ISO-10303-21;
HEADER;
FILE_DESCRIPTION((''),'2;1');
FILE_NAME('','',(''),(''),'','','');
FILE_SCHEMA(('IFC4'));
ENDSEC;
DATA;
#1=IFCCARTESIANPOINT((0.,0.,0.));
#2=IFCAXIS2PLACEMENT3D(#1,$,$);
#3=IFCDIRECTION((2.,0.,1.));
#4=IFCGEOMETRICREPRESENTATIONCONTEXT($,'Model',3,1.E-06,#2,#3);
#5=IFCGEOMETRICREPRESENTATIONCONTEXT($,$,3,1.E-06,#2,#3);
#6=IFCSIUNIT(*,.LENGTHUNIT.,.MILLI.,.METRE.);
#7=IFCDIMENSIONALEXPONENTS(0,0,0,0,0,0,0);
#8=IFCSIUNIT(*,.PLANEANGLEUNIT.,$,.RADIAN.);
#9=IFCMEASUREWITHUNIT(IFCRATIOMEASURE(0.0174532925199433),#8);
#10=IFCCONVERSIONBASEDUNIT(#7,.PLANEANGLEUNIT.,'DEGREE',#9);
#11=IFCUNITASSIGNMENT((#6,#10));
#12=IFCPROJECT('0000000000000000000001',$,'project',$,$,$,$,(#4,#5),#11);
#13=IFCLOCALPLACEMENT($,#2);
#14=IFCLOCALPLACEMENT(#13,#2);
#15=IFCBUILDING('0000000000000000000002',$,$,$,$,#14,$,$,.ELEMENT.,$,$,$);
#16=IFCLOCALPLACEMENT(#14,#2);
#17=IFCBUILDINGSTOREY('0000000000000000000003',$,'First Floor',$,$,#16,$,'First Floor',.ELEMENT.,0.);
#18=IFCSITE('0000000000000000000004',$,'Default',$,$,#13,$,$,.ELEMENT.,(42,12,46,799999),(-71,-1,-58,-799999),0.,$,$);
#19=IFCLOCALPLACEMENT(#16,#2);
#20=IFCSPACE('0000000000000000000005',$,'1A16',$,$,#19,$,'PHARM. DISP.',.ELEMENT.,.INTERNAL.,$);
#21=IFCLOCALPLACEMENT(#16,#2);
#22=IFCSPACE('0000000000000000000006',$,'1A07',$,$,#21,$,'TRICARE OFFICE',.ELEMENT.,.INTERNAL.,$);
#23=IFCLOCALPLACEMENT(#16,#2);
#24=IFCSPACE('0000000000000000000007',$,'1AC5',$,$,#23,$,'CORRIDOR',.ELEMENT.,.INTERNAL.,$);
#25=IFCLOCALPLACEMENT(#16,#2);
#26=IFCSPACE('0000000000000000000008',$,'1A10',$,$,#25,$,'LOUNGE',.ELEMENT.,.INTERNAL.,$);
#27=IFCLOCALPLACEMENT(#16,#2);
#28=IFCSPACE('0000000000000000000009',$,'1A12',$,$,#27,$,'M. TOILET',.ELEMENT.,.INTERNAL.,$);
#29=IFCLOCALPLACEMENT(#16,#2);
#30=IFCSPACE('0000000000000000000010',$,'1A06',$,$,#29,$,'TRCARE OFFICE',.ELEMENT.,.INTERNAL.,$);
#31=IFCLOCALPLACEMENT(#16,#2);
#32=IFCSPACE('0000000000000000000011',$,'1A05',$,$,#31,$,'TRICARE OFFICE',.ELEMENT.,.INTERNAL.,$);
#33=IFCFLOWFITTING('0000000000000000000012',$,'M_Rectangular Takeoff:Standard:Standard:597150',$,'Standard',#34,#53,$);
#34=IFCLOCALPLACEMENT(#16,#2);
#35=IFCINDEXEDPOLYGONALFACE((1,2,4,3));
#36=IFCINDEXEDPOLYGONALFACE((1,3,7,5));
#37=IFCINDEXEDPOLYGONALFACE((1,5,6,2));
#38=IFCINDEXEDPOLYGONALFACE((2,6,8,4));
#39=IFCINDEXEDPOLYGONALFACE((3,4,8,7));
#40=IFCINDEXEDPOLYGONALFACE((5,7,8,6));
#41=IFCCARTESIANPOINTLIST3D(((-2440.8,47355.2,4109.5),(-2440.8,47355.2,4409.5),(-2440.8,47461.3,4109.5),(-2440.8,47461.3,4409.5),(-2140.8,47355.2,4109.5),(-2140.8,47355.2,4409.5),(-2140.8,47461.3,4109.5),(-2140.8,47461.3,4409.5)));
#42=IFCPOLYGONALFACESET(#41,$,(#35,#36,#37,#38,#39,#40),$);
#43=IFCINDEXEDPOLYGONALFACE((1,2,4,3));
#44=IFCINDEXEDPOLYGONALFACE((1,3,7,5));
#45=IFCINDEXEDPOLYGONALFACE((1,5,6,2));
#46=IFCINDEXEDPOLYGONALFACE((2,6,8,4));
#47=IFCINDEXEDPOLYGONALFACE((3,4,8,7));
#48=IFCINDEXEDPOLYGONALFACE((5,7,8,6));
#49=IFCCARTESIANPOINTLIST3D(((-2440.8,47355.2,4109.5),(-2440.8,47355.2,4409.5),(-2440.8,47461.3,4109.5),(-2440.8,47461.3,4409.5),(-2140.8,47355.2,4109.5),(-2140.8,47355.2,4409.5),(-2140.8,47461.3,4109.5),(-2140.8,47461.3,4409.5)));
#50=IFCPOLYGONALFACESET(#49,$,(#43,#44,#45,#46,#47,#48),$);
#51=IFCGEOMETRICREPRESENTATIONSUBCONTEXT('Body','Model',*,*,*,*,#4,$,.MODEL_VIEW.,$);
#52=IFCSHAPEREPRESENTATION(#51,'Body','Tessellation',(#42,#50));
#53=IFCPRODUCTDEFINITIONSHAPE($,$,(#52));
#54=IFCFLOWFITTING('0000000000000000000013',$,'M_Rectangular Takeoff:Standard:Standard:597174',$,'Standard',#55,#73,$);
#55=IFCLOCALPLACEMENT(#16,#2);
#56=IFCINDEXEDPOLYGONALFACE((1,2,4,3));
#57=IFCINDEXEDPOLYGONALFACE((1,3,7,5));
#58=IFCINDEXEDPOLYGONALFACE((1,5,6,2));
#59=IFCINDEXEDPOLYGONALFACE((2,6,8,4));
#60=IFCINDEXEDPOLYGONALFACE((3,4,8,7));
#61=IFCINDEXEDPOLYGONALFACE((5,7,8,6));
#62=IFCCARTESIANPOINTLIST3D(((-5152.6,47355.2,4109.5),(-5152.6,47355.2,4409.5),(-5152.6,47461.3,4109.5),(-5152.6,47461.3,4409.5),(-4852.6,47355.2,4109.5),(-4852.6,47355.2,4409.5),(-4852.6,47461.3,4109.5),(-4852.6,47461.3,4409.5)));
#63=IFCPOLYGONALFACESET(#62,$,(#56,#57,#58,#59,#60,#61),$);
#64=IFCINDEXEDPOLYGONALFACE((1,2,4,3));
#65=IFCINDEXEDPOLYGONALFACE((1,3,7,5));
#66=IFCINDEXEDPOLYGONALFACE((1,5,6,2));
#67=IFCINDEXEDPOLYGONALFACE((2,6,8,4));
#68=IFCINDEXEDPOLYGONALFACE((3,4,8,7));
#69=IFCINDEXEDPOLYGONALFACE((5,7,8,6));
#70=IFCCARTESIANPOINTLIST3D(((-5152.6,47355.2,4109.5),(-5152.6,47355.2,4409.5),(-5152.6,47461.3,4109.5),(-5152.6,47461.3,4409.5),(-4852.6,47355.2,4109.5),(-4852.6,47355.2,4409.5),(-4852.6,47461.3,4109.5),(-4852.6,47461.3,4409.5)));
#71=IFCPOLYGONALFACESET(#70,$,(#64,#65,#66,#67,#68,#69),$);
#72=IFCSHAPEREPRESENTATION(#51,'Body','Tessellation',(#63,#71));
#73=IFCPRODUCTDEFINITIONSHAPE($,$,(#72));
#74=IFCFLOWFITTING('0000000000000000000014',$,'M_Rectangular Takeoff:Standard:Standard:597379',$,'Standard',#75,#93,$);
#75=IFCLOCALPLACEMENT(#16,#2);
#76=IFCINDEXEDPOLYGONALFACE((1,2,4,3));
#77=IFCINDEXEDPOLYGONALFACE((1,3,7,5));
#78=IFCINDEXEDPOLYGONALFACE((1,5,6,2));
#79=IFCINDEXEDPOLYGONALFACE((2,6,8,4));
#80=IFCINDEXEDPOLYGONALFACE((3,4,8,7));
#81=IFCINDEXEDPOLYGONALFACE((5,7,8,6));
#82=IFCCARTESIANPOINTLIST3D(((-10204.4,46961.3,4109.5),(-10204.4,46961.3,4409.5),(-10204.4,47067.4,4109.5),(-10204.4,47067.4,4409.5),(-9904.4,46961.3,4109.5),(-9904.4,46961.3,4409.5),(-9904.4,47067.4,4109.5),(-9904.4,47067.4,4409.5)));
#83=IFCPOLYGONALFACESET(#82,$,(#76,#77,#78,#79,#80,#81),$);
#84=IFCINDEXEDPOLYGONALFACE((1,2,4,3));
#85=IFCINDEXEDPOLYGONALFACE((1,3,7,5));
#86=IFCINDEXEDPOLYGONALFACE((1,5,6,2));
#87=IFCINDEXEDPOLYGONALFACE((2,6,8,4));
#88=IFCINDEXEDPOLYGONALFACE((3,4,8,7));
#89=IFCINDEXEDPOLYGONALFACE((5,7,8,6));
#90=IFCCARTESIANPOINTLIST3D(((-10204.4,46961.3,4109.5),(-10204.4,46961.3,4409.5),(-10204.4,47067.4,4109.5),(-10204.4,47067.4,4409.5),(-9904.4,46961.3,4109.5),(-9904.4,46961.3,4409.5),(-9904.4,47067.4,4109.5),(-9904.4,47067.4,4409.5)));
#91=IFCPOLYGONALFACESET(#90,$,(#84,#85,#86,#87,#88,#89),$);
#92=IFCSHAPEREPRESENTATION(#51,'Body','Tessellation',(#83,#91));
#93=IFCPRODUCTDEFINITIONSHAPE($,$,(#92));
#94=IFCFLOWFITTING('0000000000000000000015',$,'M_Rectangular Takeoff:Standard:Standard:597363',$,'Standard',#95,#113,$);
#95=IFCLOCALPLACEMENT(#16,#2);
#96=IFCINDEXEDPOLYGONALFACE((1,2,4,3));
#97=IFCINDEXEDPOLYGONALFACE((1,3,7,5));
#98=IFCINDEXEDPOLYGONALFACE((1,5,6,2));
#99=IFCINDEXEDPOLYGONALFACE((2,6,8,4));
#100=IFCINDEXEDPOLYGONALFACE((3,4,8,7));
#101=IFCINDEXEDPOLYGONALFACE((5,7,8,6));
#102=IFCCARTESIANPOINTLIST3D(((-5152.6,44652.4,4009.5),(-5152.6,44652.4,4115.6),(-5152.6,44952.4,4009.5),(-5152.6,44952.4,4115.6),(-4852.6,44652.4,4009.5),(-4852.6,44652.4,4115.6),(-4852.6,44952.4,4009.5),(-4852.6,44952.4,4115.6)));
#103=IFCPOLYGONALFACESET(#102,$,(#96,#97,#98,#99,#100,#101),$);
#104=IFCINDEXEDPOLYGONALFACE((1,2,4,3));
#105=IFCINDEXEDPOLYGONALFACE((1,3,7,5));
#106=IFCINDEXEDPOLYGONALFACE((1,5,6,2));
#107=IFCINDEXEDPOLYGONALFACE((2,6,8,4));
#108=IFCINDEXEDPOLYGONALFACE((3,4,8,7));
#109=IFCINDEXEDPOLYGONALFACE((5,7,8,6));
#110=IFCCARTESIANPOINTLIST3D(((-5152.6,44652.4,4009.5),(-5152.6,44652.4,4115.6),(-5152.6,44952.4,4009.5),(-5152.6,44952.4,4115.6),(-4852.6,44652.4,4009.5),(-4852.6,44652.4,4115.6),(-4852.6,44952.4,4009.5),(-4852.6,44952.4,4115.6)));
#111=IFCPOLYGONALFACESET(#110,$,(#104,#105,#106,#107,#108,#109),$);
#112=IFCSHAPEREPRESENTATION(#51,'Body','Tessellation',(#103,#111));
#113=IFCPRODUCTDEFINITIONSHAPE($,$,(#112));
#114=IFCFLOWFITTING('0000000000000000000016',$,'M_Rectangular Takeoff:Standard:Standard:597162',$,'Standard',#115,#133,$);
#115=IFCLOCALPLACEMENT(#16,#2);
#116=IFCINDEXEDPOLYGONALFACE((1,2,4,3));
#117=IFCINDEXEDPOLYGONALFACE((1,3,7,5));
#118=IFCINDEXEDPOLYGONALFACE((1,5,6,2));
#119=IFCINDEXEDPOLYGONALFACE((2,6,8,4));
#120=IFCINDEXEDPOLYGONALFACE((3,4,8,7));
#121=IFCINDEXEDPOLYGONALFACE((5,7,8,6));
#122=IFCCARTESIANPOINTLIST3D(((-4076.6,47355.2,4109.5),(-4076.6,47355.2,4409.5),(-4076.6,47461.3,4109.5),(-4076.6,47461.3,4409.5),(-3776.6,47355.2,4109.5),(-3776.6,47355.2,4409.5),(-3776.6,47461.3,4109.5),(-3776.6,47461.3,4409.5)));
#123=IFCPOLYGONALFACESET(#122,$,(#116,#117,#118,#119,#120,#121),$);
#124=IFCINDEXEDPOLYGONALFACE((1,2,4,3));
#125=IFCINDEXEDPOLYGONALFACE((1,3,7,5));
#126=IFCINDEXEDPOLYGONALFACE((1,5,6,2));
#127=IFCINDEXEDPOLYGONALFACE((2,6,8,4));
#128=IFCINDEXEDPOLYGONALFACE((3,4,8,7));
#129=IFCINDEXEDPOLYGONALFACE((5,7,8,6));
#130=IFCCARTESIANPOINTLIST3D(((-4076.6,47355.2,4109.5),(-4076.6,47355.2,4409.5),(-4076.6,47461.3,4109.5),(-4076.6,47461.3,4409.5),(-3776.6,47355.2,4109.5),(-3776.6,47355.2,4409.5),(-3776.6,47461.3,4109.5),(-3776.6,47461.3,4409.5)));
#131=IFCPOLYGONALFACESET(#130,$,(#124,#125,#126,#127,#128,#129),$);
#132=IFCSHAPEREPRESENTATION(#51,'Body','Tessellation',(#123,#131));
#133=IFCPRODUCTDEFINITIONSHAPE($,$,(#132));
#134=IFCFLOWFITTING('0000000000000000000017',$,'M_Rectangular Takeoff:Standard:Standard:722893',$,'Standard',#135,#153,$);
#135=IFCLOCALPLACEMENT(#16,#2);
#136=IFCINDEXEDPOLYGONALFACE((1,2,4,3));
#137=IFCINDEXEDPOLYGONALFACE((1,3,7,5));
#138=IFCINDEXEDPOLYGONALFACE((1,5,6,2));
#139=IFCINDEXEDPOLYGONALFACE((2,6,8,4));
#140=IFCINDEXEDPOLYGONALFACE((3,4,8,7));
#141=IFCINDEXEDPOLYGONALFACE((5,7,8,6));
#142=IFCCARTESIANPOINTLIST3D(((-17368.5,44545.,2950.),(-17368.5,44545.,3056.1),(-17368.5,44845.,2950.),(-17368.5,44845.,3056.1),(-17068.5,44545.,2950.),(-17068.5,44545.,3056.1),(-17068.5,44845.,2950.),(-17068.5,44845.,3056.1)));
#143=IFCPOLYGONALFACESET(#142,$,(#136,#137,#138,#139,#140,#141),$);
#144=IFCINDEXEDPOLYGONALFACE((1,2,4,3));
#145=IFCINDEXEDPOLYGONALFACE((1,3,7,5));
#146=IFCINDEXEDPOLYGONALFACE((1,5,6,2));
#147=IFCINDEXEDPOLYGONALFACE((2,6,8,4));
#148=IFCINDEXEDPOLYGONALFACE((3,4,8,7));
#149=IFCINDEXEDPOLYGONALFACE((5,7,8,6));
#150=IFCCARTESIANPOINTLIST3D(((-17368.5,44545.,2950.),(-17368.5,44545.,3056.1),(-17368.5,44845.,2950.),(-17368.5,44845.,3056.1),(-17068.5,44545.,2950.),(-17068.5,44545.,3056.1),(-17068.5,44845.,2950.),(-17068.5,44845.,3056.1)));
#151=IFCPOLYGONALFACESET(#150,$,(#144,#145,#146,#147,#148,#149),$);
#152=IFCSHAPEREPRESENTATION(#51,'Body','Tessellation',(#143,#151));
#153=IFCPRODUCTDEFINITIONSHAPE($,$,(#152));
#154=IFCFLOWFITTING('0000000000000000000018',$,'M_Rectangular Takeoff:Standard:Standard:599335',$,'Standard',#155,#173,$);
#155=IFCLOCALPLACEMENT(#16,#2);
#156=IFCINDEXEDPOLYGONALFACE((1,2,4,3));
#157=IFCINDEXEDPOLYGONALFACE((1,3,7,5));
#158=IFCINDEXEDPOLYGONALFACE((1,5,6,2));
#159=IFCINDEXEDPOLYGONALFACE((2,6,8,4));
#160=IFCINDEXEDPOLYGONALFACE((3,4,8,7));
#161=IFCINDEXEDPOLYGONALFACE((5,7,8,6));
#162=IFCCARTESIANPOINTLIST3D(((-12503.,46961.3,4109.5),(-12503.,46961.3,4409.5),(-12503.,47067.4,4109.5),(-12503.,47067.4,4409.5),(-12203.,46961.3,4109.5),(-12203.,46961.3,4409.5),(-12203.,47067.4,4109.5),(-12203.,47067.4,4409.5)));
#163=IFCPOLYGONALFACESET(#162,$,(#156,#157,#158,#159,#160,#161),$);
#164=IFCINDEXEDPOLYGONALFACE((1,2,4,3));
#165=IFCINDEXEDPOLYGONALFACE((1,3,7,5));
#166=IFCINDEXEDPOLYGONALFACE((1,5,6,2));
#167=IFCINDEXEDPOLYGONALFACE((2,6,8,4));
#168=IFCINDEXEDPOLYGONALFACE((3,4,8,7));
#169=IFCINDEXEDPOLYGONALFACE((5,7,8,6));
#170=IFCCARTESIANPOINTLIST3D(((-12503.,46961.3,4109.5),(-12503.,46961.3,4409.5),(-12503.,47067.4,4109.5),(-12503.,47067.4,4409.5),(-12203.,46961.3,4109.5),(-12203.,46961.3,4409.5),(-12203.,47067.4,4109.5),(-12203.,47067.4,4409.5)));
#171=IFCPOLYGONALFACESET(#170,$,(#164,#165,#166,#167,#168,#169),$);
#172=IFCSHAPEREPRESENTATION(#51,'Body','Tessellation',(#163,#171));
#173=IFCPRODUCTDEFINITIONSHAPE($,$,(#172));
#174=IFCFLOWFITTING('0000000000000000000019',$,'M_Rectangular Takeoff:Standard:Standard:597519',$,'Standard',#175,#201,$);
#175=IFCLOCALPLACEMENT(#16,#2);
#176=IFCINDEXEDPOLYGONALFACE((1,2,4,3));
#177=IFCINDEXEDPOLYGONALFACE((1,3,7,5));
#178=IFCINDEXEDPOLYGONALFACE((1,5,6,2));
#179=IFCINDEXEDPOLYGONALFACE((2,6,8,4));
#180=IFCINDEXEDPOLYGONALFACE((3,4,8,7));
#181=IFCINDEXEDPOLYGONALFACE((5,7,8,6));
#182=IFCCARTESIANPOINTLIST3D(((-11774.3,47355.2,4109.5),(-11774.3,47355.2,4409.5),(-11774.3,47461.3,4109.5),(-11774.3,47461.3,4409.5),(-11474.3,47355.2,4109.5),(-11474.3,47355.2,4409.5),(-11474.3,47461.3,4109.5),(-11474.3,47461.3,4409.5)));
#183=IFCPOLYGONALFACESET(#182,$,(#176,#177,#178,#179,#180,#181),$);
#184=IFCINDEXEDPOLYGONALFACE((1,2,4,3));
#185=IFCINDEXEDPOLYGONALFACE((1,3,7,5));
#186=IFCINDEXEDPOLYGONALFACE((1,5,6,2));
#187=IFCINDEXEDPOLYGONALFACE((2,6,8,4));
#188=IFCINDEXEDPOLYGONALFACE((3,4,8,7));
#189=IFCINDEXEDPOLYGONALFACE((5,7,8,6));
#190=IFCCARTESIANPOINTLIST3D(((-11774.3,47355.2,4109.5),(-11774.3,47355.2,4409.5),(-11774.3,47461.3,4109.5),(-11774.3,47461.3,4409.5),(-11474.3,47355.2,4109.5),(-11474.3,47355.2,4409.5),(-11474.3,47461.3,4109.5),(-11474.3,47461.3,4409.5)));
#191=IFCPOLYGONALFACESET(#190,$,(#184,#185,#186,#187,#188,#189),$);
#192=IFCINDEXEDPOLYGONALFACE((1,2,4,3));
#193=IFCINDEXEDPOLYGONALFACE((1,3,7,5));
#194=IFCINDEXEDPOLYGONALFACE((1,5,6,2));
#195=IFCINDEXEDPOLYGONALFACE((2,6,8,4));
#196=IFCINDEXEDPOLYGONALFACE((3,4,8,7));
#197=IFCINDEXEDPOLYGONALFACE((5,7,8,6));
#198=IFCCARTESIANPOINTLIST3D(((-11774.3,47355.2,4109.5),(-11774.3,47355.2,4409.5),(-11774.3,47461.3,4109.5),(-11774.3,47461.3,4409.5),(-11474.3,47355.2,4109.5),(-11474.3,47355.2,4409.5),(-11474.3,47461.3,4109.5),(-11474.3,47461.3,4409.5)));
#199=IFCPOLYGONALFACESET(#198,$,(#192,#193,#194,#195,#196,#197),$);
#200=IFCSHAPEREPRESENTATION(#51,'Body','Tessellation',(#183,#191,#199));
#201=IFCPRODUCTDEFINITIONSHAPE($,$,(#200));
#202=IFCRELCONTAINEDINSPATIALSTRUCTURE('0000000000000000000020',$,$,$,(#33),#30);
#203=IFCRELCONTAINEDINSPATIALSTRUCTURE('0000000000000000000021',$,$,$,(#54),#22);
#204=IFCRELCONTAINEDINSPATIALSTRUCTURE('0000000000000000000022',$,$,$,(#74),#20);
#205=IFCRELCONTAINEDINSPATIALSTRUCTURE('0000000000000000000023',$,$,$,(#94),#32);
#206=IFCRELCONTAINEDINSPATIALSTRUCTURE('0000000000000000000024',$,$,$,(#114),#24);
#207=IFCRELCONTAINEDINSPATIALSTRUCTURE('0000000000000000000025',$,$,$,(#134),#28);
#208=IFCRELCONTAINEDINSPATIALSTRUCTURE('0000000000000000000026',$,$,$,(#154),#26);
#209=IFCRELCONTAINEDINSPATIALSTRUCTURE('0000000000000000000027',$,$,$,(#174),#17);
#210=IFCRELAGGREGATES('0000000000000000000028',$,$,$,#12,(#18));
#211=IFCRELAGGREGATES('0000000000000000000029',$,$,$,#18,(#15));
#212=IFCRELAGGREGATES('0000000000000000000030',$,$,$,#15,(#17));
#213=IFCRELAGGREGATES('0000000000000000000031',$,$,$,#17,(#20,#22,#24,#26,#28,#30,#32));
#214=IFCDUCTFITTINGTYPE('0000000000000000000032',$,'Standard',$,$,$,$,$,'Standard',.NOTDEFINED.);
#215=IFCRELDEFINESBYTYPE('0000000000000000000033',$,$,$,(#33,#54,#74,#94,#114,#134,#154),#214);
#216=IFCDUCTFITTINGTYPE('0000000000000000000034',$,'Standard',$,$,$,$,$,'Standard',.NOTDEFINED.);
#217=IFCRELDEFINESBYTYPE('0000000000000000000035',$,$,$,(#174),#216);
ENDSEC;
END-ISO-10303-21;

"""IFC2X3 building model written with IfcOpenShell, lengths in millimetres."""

from ifc_helpers import new_model, entity, si_unit, converted_unit, direction, frame, frame_2d, origin, place, context, subcontext, project, spatial, rectangle, extrude, source, transform, mapped, type_object, type_shapes, element, save


model = new_model("IFC2X3")

# Units and contexts
model_context = context("Model", 3, precision=1e-06, world=origin(), true_north=direction((2.0, 0.0, 1.0)))
context_of_model = context(None, 3, precision=1e-06, world=origin(), true_north=direction((2.0, 0.0, 1.0)))
body_context = subcontext(model_context, "Body", "Model", "MODEL_VIEW")
ifc_project = project(units=[si_unit("LENGTHUNIT", "METRE", prefix="MILLI"), converted_unit("PLANEANGLEUNIT", "DEGREE", entity("IfcRatioMeasure", 0.0174532925199433), si_unit("PLANEANGLEUNIT", "RADIAN"), dimensions=[0, 0, 0, 0, 0, 0, 0])], contexts=[model_context, context_of_model])

# Site, building, storey, space
site_placement = place(None, origin())
site = spatial("IfcSite", under=ifc_project, at=site_placement, Name="Default", CompositionType="ELEMENT", RefLatitude=(42, 12, 46, 799999), RefLongitude=(-71, -1, -58, -799999), RefElevation=0.0)
building_placement = place(site_placement, origin())
building = spatial("IfcBuilding", under=site, at=building_placement, CompositionType="ELEMENT")
storey_placement = place(building_placement, origin())
storey = spatial("IfcBuildingStorey", under=building, at=storey_placement, Name="First Floor", LongName="First Floor", CompositionType="ELEMENT", Elevation=0.0)
space_1_placement = place(storey_placement, origin())
space_1 = spatial("IfcSpace", under=storey, at=space_1_placement, Name="1A16", LongName="PHARM. DISP.", CompositionType="ELEMENT", InteriorOrExteriorSpace="INTERNAL")

# Shared definitions
space_2_placement = place(storey_placement, origin())
space_2 = spatial("IfcSpace", under=storey, at=space_2_placement, Name="1A07", LongName="TRICARE OFFICE", CompositionType="ELEMENT", InteriorOrExteriorSpace="INTERNAL")

# Shared definitions
space_3_placement = place(storey_placement, origin())
space_3 = spatial("IfcSpace", under=storey, at=space_3_placement, Name="1AC5", LongName="CORRIDOR", CompositionType="ELEMENT", InteriorOrExteriorSpace="INTERNAL")

# Shared definitions
space_4_placement = place(storey_placement, origin())
space_4 = spatial("IfcSpace", under=storey, at=space_4_placement, Name="1A10", LongName="LOUNGE", CompositionType="ELEMENT", InteriorOrExteriorSpace="INTERNAL")

# Shared definitions
space_5_placement = place(storey_placement, origin())
space_5 = spatial("IfcSpace", under=storey, at=space_5_placement, Name="1A12", LongName="M. TOILET", CompositionType="ELEMENT", InteriorOrExteriorSpace="INTERNAL")

# Shared definitions
space_6_placement = place(storey_placement, origin())
space_6 = spatial("IfcSpace", under=storey, at=space_6_placement, Name="1A06", LongName="TRCARE OFFICE", CompositionType="ELEMENT", InteriorOrExteriorSpace="INTERNAL")

# Flow fittings
duct_fitting_type_1 = type_object("IfcDuctFittingType", Name="Standard", ElementType="Standard", PredefinedType="NOTDEFINED")
shared_shape_1 = source(origin(), body_context, "Body", "SweptSolid", [
    extrude(rectangle(XDim=300.0, YDim=106.1, at=frame_2d((0.0, 0.0), x_axis=(1.0, 0.0))), frame((47.0, 0.0, -150.0), z_axis=(0.0, 0.0, 1.0), x_axis=(0.0, -1.0, 0.0)), (0.0, 0.0, 1.0), 300.0),
    extrude(rectangle(XDim=300.0, YDim=106.1, at=frame_2d((0.0, 0.0), x_axis=(1.0, 0.0))), frame((47.0, 0.0, -150.0), z_axis=(0.0, 0.0, 1.0), x_axis=(0.0, -1.0, 0.0)), (0.0, 0.0, 1.0), 300.0),
])
type_shapes(duct_fitting_type_1, [shared_shape_1])
flow_fitting_1_placement = place(space_6_placement, frame((-2290.8, 47361.3, 4259.5), z_axis=(0.0, 0.0, -1.0), x_axis=(0.0, 1.0, 0.0)))
element("IfcFlowFitting", 1, at=flow_fitting_1_placement, inside=space_6, type_object=duct_fitting_type_1, Name="M_Rectangular Takeoff:Standard:Standard:597150", ObjectType="Standard", context=body_context, shape_type="MappedRepresentation", body=[
    mapped(shared_shape_1, transform((0.0, 0.0, 0.0), scale=1.0)),
])
flow_fitting_2_placement = place(space_2_placement, frame((-5002.6, 47361.3, 4259.5), z_axis=(0.0, 0.0, -1.0), x_axis=(0.0, 1.0, 0.0)))
element("IfcFlowFitting", 2, at=flow_fitting_2_placement, inside=space_2, type_object=duct_fitting_type_1, Name="M_Rectangular Takeoff:Standard:Standard:597174", ObjectType="Standard", context=body_context, shape_type="MappedRepresentation", body=[
    mapped(shared_shape_1, transform((0.0, 0.0, 0.0), scale=1.0)),
])
flow_fitting_3_placement = place(space_1_placement, frame((-10054.4, 47061.3, 4259.5), z_axis=(0.0, 0.0, -1.0), x_axis=(0.0, -1.0, 0.0)))
element("IfcFlowFitting", 3, at=flow_fitting_3_placement, inside=space_1, type_object=duct_fitting_type_1, Name="M_Rectangular Takeoff:Standard:Standard:597379", ObjectType="Standard", context=body_context, shape_type="MappedRepresentation", body=[
    mapped(shared_shape_1, transform((0.0, 0.0, 0.0), scale=1.0)),
])

# Shared definitions
space_7_placement = place(storey_placement, origin())
space_7 = spatial("IfcSpace", under=storey, at=space_7_placement, Name="1A05", LongName="TRICARE OFFICE", CompositionType="ELEMENT", InteriorOrExteriorSpace="INTERNAL")

# Flow fittings
flow_fitting_4_placement = place(space_7_placement, frame((-5002.6, 44802.4, 4109.5), z_axis=(0.0, -1.0, 0.0), x_axis=(0.0, 0.0, -1.0)))
element("IfcFlowFitting", 4, at=flow_fitting_4_placement, inside=space_7, type_object=duct_fitting_type_1, Name="M_Rectangular Takeoff:Standard:Standard:597363", ObjectType="Standard", context=body_context, shape_type="MappedRepresentation", body=[
    mapped(shared_shape_1, transform((0.0, 0.0, 0.0), scale=1.0)),
])
flow_fitting_5_placement = place(space_3_placement, frame((-3926.6, 47361.3, 4259.5), z_axis=(0.0, 0.0, -1.0), x_axis=(0.0, 1.0, 0.0)))
element("IfcFlowFitting", 5, at=flow_fitting_5_placement, inside=space_3, type_object=duct_fitting_type_1, Name="M_Rectangular Takeoff:Standard:Standard:597162", ObjectType="Standard", context=body_context, shape_type="MappedRepresentation", body=[
    mapped(shared_shape_1, transform((0.0, 0.0, 0.0), scale=1.0)),
])
flow_fitting_6_placement = place(space_5_placement, frame((-17218.5, 44695.0, 3050.0), z_axis=(0.0, -1.0, 0.0), x_axis=(0.0, 0.0, -1.0)))
element("IfcFlowFitting", 6, at=flow_fitting_6_placement, inside=space_5, type_object=duct_fitting_type_1, Name="M_Rectangular Takeoff:Standard:Standard:722893", ObjectType="Standard", context=body_context, shape_type="MappedRepresentation", body=[
    mapped(shared_shape_1, transform((0.0, 0.0, 0.0), scale=1.0)),
])
flow_fitting_7_placement = place(space_4_placement, frame((-12353.0, 47061.3, 4259.5), z_axis=(0.0, 0.0, -1.0), x_axis=(0.0, -1.0, 0.0)))
element("IfcFlowFitting", 7, at=flow_fitting_7_placement, inside=space_4, type_object=duct_fitting_type_1, Name="M_Rectangular Takeoff:Standard:Standard:599335", ObjectType="Standard", context=body_context, shape_type="MappedRepresentation", body=[
    mapped(shared_shape_1, transform((0.0, 0.0, 0.0), scale=1.0)),
])
duct_fitting_type_2 = type_object("IfcDuctFittingType", Name="Standard", ElementType="Standard", PredefinedType="NOTDEFINED")
shared_shape_2 = source(origin(), body_context, "Body", "SweptSolid", [
    extrude(rectangle(XDim=106.1, YDim=300.0, at=frame_2d((0.0, 0.0), x_axis=(1.0, 0.0))), frame((47.0, 0.0, -150.0)), (0.0, 0.0, 1.0), 300.0),
    extrude(rectangle(XDim=106.1, YDim=300.0, at=frame_2d((0.0, 0.0), x_axis=(1.0, 0.0))), frame((47.0, 0.0, -150.0)), (0.0, 0.0, 1.0), 300.0),
    extrude(rectangle(XDim=106.1, YDim=300.0, at=frame_2d((0.0, 0.0), x_axis=(1.0, 0.0))), frame((47.0, 0.0, -150.0)), (0.0, 0.0, 1.0), 300.0),
])
type_shapes(duct_fitting_type_2, [shared_shape_2])
flow_fitting_8_placement = place(storey_placement, frame((-11624.3, 47361.3, 4259.5), z_axis=(0.0, 0.0, -1.0), x_axis=(0.0, 1.0, 0.0)))
element("IfcFlowFitting", 8, at=flow_fitting_8_placement, inside=storey, type_object=duct_fitting_type_2, Name="M_Rectangular Takeoff:Standard:Standard:597519", ObjectType="Standard", context=body_context, shape_type="MappedRepresentation", body=[
    mapped(shared_shape_2, transform((0.0, 0.0, 0.0), scale=1.0)),
])

save(model, "model.ifc")
